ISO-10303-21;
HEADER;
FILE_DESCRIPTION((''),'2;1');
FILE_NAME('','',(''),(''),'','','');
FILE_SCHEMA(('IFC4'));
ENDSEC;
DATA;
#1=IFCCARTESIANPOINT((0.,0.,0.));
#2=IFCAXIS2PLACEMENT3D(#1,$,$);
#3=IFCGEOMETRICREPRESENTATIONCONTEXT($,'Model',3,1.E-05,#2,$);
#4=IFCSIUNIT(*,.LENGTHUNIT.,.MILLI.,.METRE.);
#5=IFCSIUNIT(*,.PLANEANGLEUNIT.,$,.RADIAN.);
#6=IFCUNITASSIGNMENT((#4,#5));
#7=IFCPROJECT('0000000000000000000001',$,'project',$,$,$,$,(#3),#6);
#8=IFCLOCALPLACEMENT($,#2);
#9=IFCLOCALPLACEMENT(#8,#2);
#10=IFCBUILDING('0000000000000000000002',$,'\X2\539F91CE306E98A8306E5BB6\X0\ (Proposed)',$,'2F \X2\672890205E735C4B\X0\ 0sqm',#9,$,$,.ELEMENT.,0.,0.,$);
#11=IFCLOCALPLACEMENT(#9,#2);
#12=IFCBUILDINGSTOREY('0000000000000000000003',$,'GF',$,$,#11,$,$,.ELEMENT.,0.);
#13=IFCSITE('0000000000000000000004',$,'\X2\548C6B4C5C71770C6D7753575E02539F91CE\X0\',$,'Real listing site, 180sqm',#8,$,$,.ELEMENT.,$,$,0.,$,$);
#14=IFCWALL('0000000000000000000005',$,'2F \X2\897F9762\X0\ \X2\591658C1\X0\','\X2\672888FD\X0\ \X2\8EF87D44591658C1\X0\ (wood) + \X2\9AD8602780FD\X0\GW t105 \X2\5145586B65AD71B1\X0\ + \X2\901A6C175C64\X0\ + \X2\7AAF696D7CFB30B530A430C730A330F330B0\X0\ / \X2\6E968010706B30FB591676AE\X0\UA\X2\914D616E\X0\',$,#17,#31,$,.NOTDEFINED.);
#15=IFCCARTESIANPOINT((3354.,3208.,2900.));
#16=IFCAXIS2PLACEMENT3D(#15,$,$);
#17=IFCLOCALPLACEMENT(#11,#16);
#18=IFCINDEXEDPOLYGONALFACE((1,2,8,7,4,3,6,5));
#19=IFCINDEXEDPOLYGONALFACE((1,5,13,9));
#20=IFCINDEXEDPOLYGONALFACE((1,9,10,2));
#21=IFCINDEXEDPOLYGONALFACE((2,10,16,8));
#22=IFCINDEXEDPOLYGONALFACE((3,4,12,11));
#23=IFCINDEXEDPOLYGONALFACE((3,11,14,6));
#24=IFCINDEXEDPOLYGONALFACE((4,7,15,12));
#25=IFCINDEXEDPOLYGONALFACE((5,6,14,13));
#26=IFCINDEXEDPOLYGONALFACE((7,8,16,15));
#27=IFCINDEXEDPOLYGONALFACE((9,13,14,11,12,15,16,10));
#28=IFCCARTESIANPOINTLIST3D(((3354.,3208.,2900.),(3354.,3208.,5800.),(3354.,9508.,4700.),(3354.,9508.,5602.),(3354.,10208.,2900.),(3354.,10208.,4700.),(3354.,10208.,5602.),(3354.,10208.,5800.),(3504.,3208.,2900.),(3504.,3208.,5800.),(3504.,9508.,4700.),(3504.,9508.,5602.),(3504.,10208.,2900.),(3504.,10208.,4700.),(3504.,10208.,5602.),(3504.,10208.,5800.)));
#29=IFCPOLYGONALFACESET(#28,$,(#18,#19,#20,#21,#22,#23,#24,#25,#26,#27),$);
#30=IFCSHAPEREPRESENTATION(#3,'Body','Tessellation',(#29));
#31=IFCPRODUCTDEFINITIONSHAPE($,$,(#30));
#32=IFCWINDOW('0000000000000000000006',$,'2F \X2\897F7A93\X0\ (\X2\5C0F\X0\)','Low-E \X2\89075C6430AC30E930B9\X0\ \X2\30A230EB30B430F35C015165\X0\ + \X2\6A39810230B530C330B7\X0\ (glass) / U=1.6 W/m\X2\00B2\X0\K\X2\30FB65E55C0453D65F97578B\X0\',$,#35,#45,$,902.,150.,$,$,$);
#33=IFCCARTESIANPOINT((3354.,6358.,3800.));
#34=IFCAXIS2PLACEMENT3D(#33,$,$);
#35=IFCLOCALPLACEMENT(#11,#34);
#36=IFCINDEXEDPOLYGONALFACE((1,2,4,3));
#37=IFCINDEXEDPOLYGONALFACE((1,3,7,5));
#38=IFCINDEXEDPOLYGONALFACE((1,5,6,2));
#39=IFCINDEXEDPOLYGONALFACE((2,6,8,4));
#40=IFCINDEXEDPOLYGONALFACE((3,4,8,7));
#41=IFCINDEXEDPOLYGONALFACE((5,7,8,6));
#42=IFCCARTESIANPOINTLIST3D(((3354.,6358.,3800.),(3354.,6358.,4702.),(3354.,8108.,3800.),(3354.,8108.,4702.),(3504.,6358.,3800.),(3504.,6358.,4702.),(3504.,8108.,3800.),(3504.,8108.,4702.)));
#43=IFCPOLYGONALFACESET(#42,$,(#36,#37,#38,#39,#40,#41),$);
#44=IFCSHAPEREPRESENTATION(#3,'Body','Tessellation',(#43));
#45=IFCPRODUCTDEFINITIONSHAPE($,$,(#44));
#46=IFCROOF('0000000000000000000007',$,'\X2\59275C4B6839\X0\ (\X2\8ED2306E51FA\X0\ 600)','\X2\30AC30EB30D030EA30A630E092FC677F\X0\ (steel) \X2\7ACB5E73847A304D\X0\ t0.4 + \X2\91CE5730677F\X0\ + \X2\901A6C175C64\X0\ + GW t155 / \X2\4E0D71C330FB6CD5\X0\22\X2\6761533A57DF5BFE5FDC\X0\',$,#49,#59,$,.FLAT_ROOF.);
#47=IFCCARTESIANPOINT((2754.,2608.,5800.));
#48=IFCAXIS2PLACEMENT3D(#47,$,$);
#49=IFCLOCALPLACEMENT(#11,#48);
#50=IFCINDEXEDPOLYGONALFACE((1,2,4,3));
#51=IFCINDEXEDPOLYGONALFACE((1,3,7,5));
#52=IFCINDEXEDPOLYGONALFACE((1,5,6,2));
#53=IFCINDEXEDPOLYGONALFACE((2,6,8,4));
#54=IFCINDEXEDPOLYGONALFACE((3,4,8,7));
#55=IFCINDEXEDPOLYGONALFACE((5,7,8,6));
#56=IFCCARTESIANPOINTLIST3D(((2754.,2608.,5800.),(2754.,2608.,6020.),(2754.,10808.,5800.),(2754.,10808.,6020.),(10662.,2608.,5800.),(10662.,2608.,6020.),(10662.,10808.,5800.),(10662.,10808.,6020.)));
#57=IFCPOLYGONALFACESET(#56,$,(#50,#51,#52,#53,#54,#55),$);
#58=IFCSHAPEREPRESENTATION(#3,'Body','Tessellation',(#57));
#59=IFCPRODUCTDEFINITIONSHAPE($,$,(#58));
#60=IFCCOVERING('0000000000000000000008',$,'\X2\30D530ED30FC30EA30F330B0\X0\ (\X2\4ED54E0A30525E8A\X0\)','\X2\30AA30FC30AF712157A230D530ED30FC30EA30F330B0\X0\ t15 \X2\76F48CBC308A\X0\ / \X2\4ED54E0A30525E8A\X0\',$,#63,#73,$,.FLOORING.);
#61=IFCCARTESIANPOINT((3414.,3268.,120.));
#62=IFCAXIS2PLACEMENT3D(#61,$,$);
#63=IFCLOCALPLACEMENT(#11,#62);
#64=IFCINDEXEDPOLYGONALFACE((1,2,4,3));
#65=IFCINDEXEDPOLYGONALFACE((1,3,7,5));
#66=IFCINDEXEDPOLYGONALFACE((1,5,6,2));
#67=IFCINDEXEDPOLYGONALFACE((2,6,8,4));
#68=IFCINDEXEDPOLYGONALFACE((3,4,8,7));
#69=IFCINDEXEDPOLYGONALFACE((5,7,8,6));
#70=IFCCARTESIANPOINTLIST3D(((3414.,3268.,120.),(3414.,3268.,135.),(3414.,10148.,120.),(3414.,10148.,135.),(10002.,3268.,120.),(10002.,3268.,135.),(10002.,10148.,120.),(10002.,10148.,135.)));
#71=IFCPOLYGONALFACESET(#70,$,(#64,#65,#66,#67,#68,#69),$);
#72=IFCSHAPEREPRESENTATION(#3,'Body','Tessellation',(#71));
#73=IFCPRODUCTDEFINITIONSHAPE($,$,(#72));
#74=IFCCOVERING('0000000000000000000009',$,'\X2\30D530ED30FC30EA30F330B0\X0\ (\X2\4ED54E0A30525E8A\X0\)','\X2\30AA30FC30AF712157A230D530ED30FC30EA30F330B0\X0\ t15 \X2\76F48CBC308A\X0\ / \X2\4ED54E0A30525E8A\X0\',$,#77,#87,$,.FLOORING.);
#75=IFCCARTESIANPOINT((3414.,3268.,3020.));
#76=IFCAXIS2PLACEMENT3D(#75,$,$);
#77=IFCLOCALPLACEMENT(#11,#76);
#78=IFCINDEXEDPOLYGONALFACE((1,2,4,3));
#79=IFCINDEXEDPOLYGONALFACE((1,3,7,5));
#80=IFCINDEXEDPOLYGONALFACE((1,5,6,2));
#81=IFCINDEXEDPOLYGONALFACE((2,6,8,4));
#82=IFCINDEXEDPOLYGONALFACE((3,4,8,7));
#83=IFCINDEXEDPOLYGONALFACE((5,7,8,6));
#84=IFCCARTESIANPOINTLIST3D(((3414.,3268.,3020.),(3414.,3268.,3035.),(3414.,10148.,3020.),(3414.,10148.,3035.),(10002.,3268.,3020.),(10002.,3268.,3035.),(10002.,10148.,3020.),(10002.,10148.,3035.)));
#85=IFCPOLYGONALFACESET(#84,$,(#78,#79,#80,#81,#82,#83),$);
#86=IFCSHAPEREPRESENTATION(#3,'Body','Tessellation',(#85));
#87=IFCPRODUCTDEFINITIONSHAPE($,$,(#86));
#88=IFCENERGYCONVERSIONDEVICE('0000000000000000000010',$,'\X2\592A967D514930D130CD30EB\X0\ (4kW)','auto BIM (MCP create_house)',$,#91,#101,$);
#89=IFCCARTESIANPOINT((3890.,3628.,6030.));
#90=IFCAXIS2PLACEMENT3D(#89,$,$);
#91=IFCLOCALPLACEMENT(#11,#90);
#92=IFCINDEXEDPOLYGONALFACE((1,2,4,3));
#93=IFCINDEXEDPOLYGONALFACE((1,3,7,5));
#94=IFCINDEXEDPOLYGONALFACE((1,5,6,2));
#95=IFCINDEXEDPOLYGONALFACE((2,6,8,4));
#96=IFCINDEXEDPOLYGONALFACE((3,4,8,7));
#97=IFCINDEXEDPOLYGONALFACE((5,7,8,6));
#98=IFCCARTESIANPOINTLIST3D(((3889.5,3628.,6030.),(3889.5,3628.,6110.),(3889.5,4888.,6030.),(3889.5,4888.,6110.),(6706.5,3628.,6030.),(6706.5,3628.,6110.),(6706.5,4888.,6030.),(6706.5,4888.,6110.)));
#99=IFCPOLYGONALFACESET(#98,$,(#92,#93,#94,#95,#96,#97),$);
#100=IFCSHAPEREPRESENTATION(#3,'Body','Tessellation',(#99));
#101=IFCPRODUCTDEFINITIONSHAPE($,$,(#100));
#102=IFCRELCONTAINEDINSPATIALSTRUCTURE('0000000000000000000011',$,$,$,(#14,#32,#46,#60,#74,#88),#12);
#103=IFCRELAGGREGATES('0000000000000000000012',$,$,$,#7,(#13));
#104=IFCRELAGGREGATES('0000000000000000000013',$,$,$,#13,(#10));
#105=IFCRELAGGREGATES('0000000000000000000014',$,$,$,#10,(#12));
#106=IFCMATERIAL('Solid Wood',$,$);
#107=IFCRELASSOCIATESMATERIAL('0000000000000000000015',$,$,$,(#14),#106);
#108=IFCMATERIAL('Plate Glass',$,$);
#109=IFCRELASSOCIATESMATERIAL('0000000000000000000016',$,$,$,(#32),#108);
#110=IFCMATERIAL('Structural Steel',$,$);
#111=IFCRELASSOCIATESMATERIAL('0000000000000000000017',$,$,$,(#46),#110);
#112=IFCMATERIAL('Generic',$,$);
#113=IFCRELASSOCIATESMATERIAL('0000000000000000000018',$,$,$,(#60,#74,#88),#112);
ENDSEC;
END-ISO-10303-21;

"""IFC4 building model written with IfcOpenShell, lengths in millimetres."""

from ifc_helpers import new_model, si_unit, frame, frame_2d, origin, place, context, project, spatial, rectangle, extrude, material, element, fill, save


model = new_model("IFC4")

# Units and contexts
model_context = context("Model", 3, precision=1e-05, world=origin())
ifc_project = project(units=[si_unit("LENGTHUNIT", "METRE", prefix="MILLI"), si_unit("PLANEANGLEUNIT", "RADIAN")], contexts=[model_context])

# Site, building, storey
site_placement = place(None, origin())
site = spatial("IfcSite", under=ifc_project, at=site_placement, Name="和歌山県海南市原野", ObjectType="Real listing site, 180sqm", CompositionType="ELEMENT", RefElevation=0.0)
building_placement = place(site_placement, origin())
building = spatial("IfcBuilding", under=site, at=building_placement, Name="原野の風の家 (Proposed)", ObjectType="2F 木造平屋 0sqm", CompositionType="ELEMENT", ElevationOfRefHeight=0.0, ElevationOfTerrain=0.0)
storey_placement = place(building_placement, origin())
storey = spatial("IfcBuildingStorey", under=building, at=storey_placement, Name="GF", CompositionType="ELEMENT", Elevation=0.0)

# Shared definitions
ifc_material_1 = material(Name="Solid Wood")

# Shared definitions
ifc_material_2 = material(Name="Plate Glass")

# Wall, opening, window
wall_1_placement = place(storey_placement, frame((3354.0, 3208.0, 2900.0)))
wall_1 = element("IfcWall", 1, at=wall_1_placement, inside=storey, material=ifc_material_1, Name="2F 西面 外壁", Description="木製 軸組外壁 (wood) + 高性能GW t105 充填断熱 + 通気層 + 窯業系サイディング / 準耐火・外皮UA配慮", PredefinedType="NOTDEFINED", context=model_context, shape_type="SweptSolid", body=[
    extrude(rectangle(XDim=150.0, YDim=7000.0, at=frame_2d((75.0, 3500.0))), frame((3354.0, 3208.0, 2900.0)), (0.0, 0.0, 1.0), 2900.0),
])
opening_1_placement = place(storey_placement, frame((3354.0, 6358.0, 3800.0)))
opening_1 = element("IfcOpeningElement", 2, at=opening_1_placement, cuts=wall_1, PredefinedType="NOTDEFINED", context=model_context, shape_type="SweptSolid", body=[
    extrude(rectangle(XDim=150.0, YDim=1750.0, at=frame_2d((75.0, 875.0))), frame((3354.0, 6358.0, 3800.0)), (0.0, 0.0, 1.0), 902.0),
])
window_1_placement = place(storey_placement, frame((3354.0, 6358.0, 3800.0)))
window_1 = element("IfcWindow", 3, at=window_1_placement, inside=storey, material=ifc_material_2, Name="2F 西窓 (小)", Description="Low-E 複層ガラス アルゴン封入 + 樹脂サッシ (glass) / U=1.6 W/m²K・日射取得型", OverallHeight=902.0, OverallWidth=150.0, context=model_context, shape_type="SweptSolid", body=[
    extrude(rectangle(XDim=150.0, YDim=1750.0, at=frame_2d((75.0, 875.0))), frame((3354.0, 6358.0, 3800.0)), (0.0, 0.0, 1.0), 902.0),
])
fill(opening_1, window_1)

# Roof
ifc_material_3 = material(Name="Structural Steel")
roof_placement = place(storey_placement, frame((2754.0, 2608.0, 5800.0)))
element("IfcRoof", 4, at=roof_placement, inside=storey, material=ifc_material_3, Name="大屋根 (軒の出 600)", Description="ガルバリウム鋼板 (steel) 立平葺き t0.4 + 野地板 + 通気層 + GW t155 / 不燃・法22条区域対応", PredefinedType="FLAT_ROOF", context=model_context, shape_type="SweptSolid", body=[
    extrude(rectangle(XDim=7908.0, YDim=8200.0, at=frame_2d((3954.0, 4100.0))), frame((2754.0, 2608.0, 5800.0)), (0.0, 0.0, 1.0), 220.0),
])

# Coverings
ifc_material_4 = material(Name="Generic")
covering_1_placement = place(storey_placement, frame((3414.0, 3268.0, 120.0)))
element("IfcCovering", 5, at=covering_1_placement, inside=storey, material=ifc_material_4, Name="フローリング (仕上げ床)", Description="オーク無垢フローリング t15 直貼り / 仕上げ床", PredefinedType="FLOORING", context=model_context, shape_type="SweptSolid", body=[
    extrude(rectangle(XDim=6588.0, YDim=6880.0, at=frame_2d((3294.0, 3440.0))), frame((3414.0, 3268.0, 120.0)), (0.0, 0.0, 1.0), 15.0),
])
covering_2_placement = place(storey_placement, frame((3414.0, 3268.0, 3020.0)))
element("IfcCovering", 6, at=covering_2_placement, inside=storey, material=ifc_material_4, Name="フローリング (仕上げ床)", Description="オーク無垢フローリング t15 直貼り / 仕上げ床", PredefinedType="FLOORING", context=model_context, shape_type="SweptSolid", body=[
    extrude(rectangle(XDim=6588.0, YDim=6880.0, at=frame_2d((3294.0, 3440.0))), frame((3414.0, 3268.0, 3020.0)), (0.0, 0.0, 1.0), 15.0),
])

# Energy conversion device
energy_conversion_device_placement = place(storey_placement, frame((3890.0, 3628.0, 6030.0)))
element("IfcEnergyConversionDevice", 7, at=energy_conversion_device_placement, inside=storey, material=ifc_material_4, Name="太陽光パネル (4kW)", Description="auto BIM (MCP create_house)", context=model_context, shape_type="SweptSolid", body=[
    extrude(rectangle(XDim=2817.0, YDim=1260.0, at=frame_2d((1408.0, 630.0))), frame((3890.0, 3628.0, 6030.0)), (0.0, 0.0, 1.0), 80.0),
])

save(model, "model.ifc")
